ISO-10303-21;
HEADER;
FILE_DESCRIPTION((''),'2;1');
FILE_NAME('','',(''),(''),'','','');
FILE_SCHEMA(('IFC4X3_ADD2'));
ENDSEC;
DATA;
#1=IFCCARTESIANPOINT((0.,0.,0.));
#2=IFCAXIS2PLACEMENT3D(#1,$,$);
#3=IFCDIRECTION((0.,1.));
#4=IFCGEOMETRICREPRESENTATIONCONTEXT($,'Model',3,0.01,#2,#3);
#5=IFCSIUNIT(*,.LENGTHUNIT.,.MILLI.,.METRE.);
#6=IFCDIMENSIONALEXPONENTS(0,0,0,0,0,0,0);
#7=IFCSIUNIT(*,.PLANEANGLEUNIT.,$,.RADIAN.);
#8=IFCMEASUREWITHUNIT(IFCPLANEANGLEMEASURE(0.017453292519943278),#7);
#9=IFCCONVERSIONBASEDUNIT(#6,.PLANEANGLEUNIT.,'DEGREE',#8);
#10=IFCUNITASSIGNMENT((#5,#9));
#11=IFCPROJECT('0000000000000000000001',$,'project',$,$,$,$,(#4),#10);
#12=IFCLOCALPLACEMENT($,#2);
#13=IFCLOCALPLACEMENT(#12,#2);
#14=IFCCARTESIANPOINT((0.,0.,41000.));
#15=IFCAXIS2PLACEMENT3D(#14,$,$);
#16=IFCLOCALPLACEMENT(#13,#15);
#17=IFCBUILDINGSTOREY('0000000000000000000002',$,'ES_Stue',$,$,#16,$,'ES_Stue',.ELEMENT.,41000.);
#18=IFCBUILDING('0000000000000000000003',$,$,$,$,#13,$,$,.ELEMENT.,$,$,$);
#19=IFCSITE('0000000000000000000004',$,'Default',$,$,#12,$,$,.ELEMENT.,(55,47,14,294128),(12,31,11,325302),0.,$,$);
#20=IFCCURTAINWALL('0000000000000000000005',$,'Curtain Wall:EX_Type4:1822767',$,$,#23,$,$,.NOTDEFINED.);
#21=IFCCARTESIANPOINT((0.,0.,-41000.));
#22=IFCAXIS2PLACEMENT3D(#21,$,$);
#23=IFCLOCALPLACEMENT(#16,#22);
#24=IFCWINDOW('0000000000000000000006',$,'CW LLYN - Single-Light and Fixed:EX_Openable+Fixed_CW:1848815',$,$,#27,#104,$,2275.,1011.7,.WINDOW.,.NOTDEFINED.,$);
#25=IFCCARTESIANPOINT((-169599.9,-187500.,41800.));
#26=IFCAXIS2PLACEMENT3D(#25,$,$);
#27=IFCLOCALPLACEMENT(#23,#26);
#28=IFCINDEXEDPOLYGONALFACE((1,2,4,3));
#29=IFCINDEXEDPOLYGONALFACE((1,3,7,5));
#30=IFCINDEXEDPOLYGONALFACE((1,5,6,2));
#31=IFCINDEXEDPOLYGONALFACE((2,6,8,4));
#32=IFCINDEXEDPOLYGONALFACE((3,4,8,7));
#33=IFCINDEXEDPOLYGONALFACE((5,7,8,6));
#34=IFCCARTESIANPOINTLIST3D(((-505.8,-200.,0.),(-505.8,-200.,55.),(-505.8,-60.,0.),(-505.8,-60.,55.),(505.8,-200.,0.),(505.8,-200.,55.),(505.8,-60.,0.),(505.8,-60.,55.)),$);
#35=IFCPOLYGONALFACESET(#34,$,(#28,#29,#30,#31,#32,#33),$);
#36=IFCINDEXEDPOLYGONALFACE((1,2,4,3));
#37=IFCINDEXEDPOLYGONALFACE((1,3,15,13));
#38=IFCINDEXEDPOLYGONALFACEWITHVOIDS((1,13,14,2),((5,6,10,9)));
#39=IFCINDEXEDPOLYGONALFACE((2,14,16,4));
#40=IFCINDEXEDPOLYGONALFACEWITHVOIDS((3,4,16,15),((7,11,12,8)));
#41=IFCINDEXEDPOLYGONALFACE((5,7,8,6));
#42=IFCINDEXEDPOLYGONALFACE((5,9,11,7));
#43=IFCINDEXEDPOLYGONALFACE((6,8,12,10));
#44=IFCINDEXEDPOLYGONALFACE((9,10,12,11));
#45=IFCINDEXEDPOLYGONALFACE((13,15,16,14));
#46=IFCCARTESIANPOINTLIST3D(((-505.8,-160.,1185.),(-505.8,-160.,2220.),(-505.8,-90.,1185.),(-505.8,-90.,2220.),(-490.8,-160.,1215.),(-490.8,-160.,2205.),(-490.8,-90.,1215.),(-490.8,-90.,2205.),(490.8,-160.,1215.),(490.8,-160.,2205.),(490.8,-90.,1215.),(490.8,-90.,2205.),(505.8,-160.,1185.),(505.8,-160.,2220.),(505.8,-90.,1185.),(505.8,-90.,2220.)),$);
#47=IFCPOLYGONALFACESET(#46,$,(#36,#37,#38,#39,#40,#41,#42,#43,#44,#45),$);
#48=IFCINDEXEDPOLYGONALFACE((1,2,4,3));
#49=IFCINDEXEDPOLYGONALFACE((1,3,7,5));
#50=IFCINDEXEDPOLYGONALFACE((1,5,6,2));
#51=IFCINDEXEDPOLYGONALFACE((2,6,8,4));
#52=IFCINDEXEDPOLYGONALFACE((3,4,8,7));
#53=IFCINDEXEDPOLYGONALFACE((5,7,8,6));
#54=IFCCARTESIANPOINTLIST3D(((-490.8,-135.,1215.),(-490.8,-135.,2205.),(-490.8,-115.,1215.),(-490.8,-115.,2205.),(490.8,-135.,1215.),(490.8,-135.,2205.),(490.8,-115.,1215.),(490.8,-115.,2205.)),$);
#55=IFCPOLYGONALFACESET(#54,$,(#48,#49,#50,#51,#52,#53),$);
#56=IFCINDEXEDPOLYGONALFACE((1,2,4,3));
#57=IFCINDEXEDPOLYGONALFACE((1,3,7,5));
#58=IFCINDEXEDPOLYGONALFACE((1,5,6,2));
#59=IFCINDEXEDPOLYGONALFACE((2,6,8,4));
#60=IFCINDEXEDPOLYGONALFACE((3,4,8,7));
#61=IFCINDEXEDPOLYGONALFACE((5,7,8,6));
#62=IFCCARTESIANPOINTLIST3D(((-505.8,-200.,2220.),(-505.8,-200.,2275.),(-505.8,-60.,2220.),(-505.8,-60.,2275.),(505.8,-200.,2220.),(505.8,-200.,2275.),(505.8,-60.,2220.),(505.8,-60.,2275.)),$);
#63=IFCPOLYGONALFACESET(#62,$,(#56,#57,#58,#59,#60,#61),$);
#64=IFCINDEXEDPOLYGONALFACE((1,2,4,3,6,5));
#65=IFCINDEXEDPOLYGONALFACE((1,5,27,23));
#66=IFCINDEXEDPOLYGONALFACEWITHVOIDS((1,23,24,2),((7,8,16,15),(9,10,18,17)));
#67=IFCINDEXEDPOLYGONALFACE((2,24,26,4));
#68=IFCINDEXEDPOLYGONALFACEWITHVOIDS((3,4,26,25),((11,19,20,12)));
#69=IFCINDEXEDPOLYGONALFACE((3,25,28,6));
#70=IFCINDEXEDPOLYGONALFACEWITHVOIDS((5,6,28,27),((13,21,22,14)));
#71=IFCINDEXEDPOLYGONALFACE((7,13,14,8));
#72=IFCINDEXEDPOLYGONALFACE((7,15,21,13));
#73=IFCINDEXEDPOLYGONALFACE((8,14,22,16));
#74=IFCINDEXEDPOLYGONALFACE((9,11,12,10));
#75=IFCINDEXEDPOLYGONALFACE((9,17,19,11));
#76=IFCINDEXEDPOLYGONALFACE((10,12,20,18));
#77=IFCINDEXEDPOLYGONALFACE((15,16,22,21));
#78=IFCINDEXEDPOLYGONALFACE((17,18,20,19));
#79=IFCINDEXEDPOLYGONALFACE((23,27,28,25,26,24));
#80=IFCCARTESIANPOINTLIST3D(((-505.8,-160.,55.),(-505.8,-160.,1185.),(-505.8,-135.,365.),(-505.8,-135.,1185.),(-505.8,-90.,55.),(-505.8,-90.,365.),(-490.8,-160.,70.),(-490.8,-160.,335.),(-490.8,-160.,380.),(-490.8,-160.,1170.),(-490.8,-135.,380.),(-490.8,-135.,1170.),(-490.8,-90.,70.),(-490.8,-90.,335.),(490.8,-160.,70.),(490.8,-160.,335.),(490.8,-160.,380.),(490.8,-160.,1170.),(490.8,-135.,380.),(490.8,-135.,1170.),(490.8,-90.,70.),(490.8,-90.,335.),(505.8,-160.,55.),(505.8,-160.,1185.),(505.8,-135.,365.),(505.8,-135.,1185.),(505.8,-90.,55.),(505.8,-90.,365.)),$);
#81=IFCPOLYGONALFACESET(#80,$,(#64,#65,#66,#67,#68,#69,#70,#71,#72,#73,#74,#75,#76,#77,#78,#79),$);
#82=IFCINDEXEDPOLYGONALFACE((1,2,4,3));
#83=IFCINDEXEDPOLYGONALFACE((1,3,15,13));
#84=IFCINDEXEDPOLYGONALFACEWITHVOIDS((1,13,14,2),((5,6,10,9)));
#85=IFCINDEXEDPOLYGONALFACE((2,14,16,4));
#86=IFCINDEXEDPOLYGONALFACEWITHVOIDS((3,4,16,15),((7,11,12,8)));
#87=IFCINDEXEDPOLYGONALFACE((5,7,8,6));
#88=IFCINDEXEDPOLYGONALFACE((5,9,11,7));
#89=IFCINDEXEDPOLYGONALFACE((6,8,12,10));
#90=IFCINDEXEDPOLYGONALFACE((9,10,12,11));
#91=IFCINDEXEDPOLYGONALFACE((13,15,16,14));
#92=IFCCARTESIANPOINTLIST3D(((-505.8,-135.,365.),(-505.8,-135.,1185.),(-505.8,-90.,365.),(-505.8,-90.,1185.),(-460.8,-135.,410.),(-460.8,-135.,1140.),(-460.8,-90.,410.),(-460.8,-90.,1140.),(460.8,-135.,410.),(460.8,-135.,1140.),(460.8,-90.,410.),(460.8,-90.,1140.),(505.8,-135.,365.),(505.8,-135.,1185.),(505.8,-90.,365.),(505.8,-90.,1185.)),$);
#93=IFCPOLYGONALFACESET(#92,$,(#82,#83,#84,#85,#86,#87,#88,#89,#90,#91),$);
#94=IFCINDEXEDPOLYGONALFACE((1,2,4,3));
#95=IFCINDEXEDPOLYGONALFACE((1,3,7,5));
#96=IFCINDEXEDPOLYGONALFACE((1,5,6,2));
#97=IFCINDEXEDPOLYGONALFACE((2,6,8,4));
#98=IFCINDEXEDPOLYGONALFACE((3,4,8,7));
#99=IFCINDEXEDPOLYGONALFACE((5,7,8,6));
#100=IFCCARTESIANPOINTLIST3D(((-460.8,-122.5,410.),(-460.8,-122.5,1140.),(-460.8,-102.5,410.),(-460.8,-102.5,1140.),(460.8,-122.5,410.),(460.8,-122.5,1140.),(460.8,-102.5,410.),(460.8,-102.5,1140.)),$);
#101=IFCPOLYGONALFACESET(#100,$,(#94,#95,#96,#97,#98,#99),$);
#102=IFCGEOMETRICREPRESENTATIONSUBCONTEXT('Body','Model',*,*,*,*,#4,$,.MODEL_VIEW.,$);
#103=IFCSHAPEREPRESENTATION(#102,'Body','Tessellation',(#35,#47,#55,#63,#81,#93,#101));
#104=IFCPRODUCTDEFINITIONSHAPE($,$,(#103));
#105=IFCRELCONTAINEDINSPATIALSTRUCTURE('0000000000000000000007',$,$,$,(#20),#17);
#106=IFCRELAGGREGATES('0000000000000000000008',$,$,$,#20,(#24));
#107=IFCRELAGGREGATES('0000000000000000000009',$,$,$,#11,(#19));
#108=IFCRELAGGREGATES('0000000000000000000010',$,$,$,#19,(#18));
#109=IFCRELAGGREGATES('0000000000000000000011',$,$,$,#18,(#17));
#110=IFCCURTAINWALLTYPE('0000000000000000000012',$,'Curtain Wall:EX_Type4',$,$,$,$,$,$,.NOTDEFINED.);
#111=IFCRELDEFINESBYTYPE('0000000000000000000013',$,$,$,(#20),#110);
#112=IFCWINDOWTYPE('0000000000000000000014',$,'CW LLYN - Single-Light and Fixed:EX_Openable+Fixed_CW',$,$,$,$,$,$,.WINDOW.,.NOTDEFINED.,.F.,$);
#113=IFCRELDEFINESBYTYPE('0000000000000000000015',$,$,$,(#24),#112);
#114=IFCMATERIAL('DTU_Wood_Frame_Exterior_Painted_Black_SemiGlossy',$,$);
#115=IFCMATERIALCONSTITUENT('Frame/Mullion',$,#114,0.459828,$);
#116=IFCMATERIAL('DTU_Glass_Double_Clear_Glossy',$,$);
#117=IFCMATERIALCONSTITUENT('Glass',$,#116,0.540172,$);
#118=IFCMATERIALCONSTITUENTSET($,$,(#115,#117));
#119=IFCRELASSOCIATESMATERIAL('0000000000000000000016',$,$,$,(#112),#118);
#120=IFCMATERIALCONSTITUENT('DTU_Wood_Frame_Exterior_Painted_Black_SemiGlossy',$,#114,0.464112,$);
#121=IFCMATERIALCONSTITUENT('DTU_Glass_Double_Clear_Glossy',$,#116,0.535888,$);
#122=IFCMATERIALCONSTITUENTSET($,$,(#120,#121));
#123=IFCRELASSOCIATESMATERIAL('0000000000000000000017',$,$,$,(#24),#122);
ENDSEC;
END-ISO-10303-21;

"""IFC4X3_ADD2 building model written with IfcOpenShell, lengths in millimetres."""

from ifc_helpers import new_model, entity, si_unit, converted_unit, direction, frame, frame_2d, origin, origin_2d_with_axis, place, context, subcontext, project, spatial, polyline, rectangle, outline, extrude, source, transform, mapped, material, constituent, constituent_set, type_object, type_shapes, element, aggregate, save


model = new_model("IFC4X3_ADD2")

# Units and contexts
model_context = context("Model", 3, precision=0.01, world=origin(), true_north=direction((0.0, 1.0)))
body_context = subcontext(model_context, "Body", "Model", "MODEL_VIEW")
ifc_project = project(units=[si_unit("LENGTHUNIT", "METRE", prefix="MILLI"), converted_unit("PLANEANGLEUNIT", "DEGREE", entity("IfcPlaneAngleMeasure", 0.017453292519943278), si_unit("PLANEANGLEUNIT", "RADIAN"), dimensions=[0, 0, 0, 0, 0, 0, 0])], contexts=[model_context])

# Site, building, storey
site_placement = place(None, origin())
site = spatial("IfcSite", under=ifc_project, at=site_placement, Name="Default", CompositionType="ELEMENT", RefLatitude=(55, 47, 14, 294128), RefLongitude=(12, 31, 11, 325302), RefElevation=0.0)
building_placement = place(site_placement, origin())
building = spatial("IfcBuilding", under=site, at=building_placement, CompositionType="ELEMENT")
storey_placement = place(building_placement, frame((0.0, 0.0, 41000.0)))
storey = spatial("IfcBuildingStorey", under=building, at=storey_placement, Name="ES_Stue", LongName="ES_Stue", CompositionType="ELEMENT", Elevation=41000.0)

# Curtain wall, window, openings
curtain_wall_type = type_object("IfcCurtainWallType", Name="Curtain Wall:EX_Type4", PredefinedType="NOTDEFINED")
curtain_wall_placement = place(storey_placement, frame((0.0, 0.0, -41000.0)))
curtain_wall = element("IfcCurtainWall", 1, at=curtain_wall_placement, inside=storey, type_object=curtain_wall_type, Name="Curtain Wall:EX_Type4:1822767", PredefinedType="NOTDEFINED")
ifc_material_1 = material(Name="DTU_Wood_Frame_Exterior_Painted_Black_SemiGlossy")
ifc_material_2 = material(Name="DTU_Glass_Double_Clear_Glossy")
ifc_constituent_1 = constituent(ifc_material_1, Name="DTU_Wood_Frame_Exterior_Painted_Black_SemiGlossy", fraction=0.464112)
ifc_constituent_2 = constituent(ifc_material_2, Name="DTU_Glass_Double_Clear_Glossy", fraction=0.535888)
ifc_constituent_set_1 = constituent_set(constituents=[ifc_constituent_1, ifc_constituent_2])
ifc_constituent_3 = constituent(ifc_material_1, Name="Frame/Mullion", fraction=0.459828)
ifc_constituent_4 = constituent(ifc_material_2, Name="Glass", fraction=0.540172)
ifc_constituent_set_2 = constituent_set(constituents=[ifc_constituent_3, ifc_constituent_4])
window_type_1 = type_object("IfcWindowType", Name="CW LLYN - Single-Light and Fixed:EX_Openable+Fixed_CW", ParameterTakesPrecedence=False, PartitioningType="NOTDEFINED", PredefinedType="WINDOW", material=ifc_constituent_set_2)
shared_shape_1 = source(origin(), body_context, "Body", "SweptSolid", [
    extrude(rectangle(XDim=140.0, YDim=1011.7, at=origin_2d_with_axis()), frame((0.0, -130.0, 0.0), z_axis=(0.0, 0.0, 1.0), x_axis=(0.0, -1.0, 0.0)), (0.0, 0.0, 1.0), 55.0),
    extrude(outline(polyline([(-517.5, -505.8), (517.5, -505.8), (517.5, 505.8), (-517.5, 505.8), (-517.5, -505.8)]), holes=[polyline([(502.5, -490.8), (-487.5, -490.8), (-487.5, 490.8), (502.5, 490.8), (502.5, -490.8)])]), frame((0.0, -90.0, 1702.5), z_axis=(0.0, -1.0, 0.0), x_axis=(0.0, 0.0, 1.0)), (0.0, 0.0, 1.0), 70.0),
    extrude(rectangle(XDim=981.7, YDim=20.0, at=frame_2d((0.0, 0.0), x_axis=(1.0, 0.0))), frame((0.0, -125.0, 1215.0), z_axis=(0.0, 0.0, 1.0), x_axis=(-1.0, 0.0, 0.0)), (0.0, 0.0, 1.0), 990.0),
    extrude(rectangle(XDim=981.7, YDim=20.0, at=frame_2d((0.0, 0.0), x_axis=(1.0, 0.0))), frame((0.0, -125.0, 70.0), z_axis=(0.0, 0.0, 1.0), x_axis=(-1.0, 0.0, 0.0)), (0.0, 0.0, 1.0), 265.0),
    extrude(rectangle(XDim=140.0, YDim=1011.7, at=frame_2d((0.0, 0.0), x_axis=(1.0, 0.0))), frame((0.0, -130.0, 2220.0), z_axis=(0.0, 0.0, 1.0), x_axis=(0.0, -1.0, 0.0)), (0.0, 0.0, 1.0), 55.0),
    extrude(outline(polyline([(-38.3, -480.0), (31.7, -480.0), (31.7, 650.0), (6.7, 650.0), (6.7, -170.0), (-38.3, -170.0), (-38.3, -480.0)])), frame((505.8, -128.3, 535.0), z_axis=(-1.0, 0.0, 0.0), x_axis=(0.0, -1.0, 0.0)), (0.0, 0.0, 1.0), 1011.7),
    extrude(outline(polyline([(-410.0, -505.8), (410.0, -505.8), (410.0, 505.8), (-410.0, 505.8), (-410.0, -505.8)]), holes=[polyline([(-365.0, 460.8), (365.0, 460.8), (365.0, -460.8), (-365.0, -460.8), (-365.0, 460.8)])]), frame((0.0, -90.0, 775.0), z_axis=(0.0, -1.0, 0.0), x_axis=(0.0, 0.0, 1.0)), (0.0, 0.0, 1.0), 45.0),
    extrude(rectangle(XDim=921.7, YDim=20.0, at=frame_2d((0.0, 0.0), x_axis=(1.0, 0.0))), frame((0.0, -112.5, 410.0), z_axis=(0.0, 0.0, 1.0), x_axis=(-1.0, 0.0, 0.0)), (0.0, 0.0, 1.0), 730.0),
])
type_shapes(window_type_1, [shared_shape_1])
window_1_placement = place(curtain_wall_placement, frame((-169599.9, -187500.0, 41800.0)))
window_1 = element("IfcWindow", 2, at=window_1_placement, type_object=window_type_1, material=ifc_constituent_set_1, Name="CW LLYN - Single-Light and Fixed:EX_Openable+Fixed_CW:1848815", OverallHeight=2275.0, OverallWidth=1011.7, PartitioningType="NOTDEFINED", PredefinedType="WINDOW", context=body_context, shape_type="MappedRepresentation", body=[
    mapped(shared_shape_1, transform((0.0, 0.0, 0.0), scale=1.0)),
])
opening_1_placement = place(curtain_wall_placement, frame((-169599.9, -187500.0, 82800.0), z_axis=(0.0, 0.0, 1.0), x_axis=(-1.0, 0.0, 0.0)))
opening_1 = element("IfcOpeningElement", 3, at=opening_1_placement, cuts=window_1, PredefinedType="OPENING", context=body_context, shape_type="SweptSolid", body=[
    extrude(rectangle(XDim=265.0, YDim=981.7, at=frame_2d((0.0, 0.0), x_axis=(1.0, 0.0))), frame((0.0, 160.0, -40797.5), z_axis=(0.0, -1.0, 0.0), x_axis=(0.0, 0.0, 1.0)), (0.0, 0.0, 1.0), 70.0),
])
opening_2_placement = place(curtain_wall_placement, frame((-169599.9, -187500.0, 82800.0), z_axis=(0.0, 0.0, 1.0), x_axis=(-1.0, 0.0, 0.0)))
opening_2 = element("IfcOpeningElement", 4, at=opening_2_placement, cuts=window_1, PredefinedType="OPENING", context=body_context, shape_type="SweptSolid", body=[
    extrude(rectangle(XDim=790.0, YDim=981.7, at=frame_2d((0.0, 0.0), x_axis=(1.0, 0.0))), frame((0.0, 135.0, -40225.0), z_axis=(0.0, 1.0, 0.0), x_axis=(0.0, 0.0, 1.0)), (0.0, 0.0, 1.0), 25.0),
])
aggregate(curtain_wall, [window_1, opening_1, opening_2])

save(model, "model.ifc")
